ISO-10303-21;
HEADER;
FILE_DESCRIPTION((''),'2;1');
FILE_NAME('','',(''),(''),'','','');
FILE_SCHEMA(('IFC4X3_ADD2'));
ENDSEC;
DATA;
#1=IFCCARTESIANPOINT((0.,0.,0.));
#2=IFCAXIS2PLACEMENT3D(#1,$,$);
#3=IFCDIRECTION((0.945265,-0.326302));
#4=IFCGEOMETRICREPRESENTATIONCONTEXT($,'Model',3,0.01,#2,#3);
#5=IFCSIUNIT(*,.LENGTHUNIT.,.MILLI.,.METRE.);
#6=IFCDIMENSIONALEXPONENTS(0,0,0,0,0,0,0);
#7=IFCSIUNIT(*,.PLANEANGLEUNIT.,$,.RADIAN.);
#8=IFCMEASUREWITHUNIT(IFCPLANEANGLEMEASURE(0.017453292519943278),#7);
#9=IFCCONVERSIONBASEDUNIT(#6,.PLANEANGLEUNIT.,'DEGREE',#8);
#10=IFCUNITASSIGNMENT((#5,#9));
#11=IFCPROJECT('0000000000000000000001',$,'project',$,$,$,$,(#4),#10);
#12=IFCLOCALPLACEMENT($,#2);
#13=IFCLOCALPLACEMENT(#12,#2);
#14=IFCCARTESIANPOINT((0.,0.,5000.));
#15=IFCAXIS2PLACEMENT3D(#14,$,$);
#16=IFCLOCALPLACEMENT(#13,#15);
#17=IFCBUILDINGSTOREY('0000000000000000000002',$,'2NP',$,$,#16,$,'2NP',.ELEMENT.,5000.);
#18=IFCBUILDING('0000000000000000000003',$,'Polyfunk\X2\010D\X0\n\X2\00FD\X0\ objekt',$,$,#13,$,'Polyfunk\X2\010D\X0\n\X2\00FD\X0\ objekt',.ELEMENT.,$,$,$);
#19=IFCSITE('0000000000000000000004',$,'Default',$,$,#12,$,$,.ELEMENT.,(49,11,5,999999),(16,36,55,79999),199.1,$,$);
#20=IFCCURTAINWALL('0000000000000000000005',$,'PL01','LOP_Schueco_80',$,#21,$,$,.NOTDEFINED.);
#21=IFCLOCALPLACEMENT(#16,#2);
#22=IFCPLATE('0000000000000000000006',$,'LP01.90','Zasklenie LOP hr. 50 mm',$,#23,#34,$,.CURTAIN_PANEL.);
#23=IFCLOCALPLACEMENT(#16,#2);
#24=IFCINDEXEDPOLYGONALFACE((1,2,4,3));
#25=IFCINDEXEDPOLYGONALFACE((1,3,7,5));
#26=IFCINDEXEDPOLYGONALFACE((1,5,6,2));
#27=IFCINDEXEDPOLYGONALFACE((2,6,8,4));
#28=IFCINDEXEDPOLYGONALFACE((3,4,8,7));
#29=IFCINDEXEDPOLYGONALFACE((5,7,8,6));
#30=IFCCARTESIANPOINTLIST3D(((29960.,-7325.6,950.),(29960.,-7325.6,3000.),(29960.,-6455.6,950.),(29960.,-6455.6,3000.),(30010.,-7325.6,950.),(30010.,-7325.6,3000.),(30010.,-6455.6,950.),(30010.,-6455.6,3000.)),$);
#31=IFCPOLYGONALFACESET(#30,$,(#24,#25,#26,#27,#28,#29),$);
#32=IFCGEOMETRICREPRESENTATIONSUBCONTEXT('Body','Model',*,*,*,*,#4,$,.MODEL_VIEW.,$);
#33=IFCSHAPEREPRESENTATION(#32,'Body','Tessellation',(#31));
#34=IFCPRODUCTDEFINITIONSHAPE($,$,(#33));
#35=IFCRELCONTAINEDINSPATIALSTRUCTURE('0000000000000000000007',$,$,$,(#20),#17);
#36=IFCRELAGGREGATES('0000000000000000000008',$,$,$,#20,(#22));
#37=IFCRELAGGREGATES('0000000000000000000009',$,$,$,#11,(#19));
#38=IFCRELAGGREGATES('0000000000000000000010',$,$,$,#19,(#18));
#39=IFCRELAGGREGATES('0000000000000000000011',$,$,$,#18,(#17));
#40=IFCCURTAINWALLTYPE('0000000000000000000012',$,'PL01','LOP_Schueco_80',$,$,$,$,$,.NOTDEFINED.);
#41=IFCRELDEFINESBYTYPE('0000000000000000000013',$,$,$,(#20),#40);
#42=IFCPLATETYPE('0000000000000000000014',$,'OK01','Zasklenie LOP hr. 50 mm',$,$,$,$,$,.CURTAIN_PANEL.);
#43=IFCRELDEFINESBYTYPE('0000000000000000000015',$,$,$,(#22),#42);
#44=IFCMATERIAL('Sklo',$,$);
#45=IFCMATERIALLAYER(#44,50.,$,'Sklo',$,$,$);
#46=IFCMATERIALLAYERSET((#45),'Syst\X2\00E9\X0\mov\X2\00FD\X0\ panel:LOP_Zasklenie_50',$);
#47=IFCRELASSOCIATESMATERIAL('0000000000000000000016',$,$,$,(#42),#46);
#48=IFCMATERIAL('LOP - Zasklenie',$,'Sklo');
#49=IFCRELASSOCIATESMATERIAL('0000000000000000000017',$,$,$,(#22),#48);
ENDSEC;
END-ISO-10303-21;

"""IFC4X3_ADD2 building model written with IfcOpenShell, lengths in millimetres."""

from ifc_helpers import new_model, entity, si_unit, converted_unit, direction, frame, origin, origin_2d_with_axis, place, context, subcontext, project, spatial, rectangle, extrude, source, transform, mapped, material, layer, layer_set, type_object, type_shapes, element, aggregate, save


model = new_model("IFC4X3_ADD2")

# Units and contexts
model_context = context("Model", 3, precision=0.01, world=origin(), true_north=direction((0.945265, -0.326302)))
body_context = subcontext(model_context, "Body", "Model", "MODEL_VIEW")
ifc_project = project(units=[si_unit("LENGTHUNIT", "METRE", prefix="MILLI"), converted_unit("PLANEANGLEUNIT", "DEGREE", entity("IfcPlaneAngleMeasure", 0.017453292519943278), si_unit("PLANEANGLEUNIT", "RADIAN"), dimensions=[0, 0, 0, 0, 0, 0, 0])], contexts=[model_context])

# Site, building, storey
site_placement = place(None, origin())
site = spatial("IfcSite", under=ifc_project, at=site_placement, Name="Default", CompositionType="ELEMENT", RefLatitude=(49, 11, 5, 999999), RefLongitude=(16, 36, 55, 79999), RefElevation=199.1)
building_placement = place(site_placement, origin())
building = spatial("IfcBuilding", under=site, at=building_placement, Name="Polyfunkčný objekt", LongName="Polyfunkčný objekt", CompositionType="ELEMENT")
storey_placement = place(building_placement, frame((0.0, 0.0, 5000.0)))
storey = spatial("IfcBuildingStorey", under=building, at=storey_placement, Name="2NP", LongName="2NP", CompositionType="ELEMENT", Elevation=5000.0)

# Curtain wall, plate
curtain_wall_type = type_object("IfcCurtainWallType", Name="PL01", Description="LOP_Schueco_80", PredefinedType="NOTDEFINED")
curtain_wall_placement = place(storey_placement, frame((0.0, 0.0, -5000.0)))
curtain_wall = element("IfcCurtainWall", 1, at=curtain_wall_placement, inside=storey, type_object=curtain_wall_type, Name="PL01", Description="LOP_Schueco_80", PredefinedType="NOTDEFINED")
ifc_material_1 = material(Name="LOP - Zasklenie", Category="Sklo")
ifc_material_2 = material(Name="Sklo")
ifc_layer_1 = layer(ifc_material_2, 50.0, Name="Sklo")
ifc_layer_set_1 = layer_set([ifc_layer_1], Name="Systémový panel:LOP_Zasklenie_50")
plate_type_1 = type_object("IfcPlateType", Name="OK01", Description="Zasklenie LOP hr. 50 mm", PredefinedType="CURTAIN_PANEL", material=ifc_layer_set_1)
shared_shape_1 = source(origin(), body_context, "Body", "SweptSolid", [
    extrude(rectangle(XDim=50.0, YDim=870.0, at=origin_2d_with_axis()), frame((0.0, -25.0, 0.0), z_axis=(0.0, 0.0, 1.0), x_axis=(0.0, 1.0, 0.0)), (0.0, 0.0, 1.0), 2050.0),
])
type_shapes(plate_type_1, [shared_shape_1])
plate_1_placement = place(curtain_wall_placement, frame((30010.0, -6890.6, 5950.0), z_axis=(0.0, 0.0, 1.0), x_axis=(0.0, -1.0, 0.0)))
plate_1 = element("IfcPlate", 2, at=plate_1_placement, type_object=plate_type_1, material=ifc_material_1, Name="LP01.90", Description="Zasklenie LOP hr. 50 mm", PredefinedType="CURTAIN_PANEL", context=body_context, shape_type="MappedRepresentation", body=[
    mapped(shared_shape_1, transform((0.0, 0.0, 0.0), scale=1.0)),
])
aggregate(curtain_wall, [plate_1])

save(model, "model.ifc")
